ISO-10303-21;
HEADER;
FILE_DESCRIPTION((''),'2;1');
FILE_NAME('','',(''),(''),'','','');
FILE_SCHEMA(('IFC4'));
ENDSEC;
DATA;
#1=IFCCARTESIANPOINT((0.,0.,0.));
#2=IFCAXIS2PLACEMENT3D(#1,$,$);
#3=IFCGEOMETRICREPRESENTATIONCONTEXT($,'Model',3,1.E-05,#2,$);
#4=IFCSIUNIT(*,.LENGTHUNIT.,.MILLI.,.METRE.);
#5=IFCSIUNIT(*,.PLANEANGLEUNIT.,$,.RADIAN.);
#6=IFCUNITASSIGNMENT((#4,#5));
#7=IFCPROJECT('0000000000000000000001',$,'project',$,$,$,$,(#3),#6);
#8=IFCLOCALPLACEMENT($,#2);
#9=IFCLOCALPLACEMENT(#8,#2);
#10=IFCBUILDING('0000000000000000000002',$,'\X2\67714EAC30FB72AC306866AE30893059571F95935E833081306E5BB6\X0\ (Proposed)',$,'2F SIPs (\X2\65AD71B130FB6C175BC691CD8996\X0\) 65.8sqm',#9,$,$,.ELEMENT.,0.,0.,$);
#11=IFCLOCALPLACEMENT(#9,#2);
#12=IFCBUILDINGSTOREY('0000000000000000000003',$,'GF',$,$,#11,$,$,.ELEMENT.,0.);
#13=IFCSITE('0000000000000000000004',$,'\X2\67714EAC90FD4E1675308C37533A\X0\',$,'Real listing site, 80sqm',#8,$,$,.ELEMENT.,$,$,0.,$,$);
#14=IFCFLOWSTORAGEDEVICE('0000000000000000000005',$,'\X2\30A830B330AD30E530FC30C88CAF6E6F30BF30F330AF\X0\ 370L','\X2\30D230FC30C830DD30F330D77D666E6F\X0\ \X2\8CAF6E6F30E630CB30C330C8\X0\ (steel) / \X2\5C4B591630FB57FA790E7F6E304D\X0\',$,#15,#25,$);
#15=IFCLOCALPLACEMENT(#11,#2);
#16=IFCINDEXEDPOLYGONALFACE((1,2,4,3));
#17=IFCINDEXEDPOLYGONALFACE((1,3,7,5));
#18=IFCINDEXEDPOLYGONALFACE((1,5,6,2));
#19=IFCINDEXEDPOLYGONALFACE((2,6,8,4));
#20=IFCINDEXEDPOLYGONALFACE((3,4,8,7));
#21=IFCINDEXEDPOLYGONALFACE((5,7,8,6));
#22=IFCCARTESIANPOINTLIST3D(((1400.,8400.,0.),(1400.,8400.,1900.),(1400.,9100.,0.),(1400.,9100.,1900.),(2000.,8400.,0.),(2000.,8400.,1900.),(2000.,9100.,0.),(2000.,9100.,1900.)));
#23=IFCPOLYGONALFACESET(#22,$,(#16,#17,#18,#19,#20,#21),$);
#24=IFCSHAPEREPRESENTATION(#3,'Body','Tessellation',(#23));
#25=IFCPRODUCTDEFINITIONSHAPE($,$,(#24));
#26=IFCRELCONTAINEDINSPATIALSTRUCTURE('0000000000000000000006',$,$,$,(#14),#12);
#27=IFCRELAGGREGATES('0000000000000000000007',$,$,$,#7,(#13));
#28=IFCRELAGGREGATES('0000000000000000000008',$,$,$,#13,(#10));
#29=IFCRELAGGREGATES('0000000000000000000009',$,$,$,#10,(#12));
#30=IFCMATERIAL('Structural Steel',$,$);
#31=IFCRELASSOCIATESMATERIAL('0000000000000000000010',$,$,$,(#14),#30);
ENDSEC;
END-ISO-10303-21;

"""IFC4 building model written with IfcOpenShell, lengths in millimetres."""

from ifc_helpers import new_model, si_unit, frame, frame_2d, origin, place, context, project, spatial, rectangle, extrude, material, element, save


model = new_model("IFC4")

# Units and contexts
model_context = context("Model", 3, precision=1e-05, world=origin())
ifc_project = project(units=[si_unit("LENGTHUNIT", "METRE", prefix="MILLI"), si_unit("PLANEANGLEUNIT", "RADIAN")], contexts=[model_context])

# Site, building, storey
site_placement = place(None, origin())
site = spatial("IfcSite", under=ifc_project, at=site_placement, Name="東京都世田谷区", ObjectType="Real listing site, 80sqm", CompositionType="ELEMENT", RefElevation=0.0)
building_placement = place(site_placement, origin())
building = spatial("IfcBuilding", under=site, at=building_placement, Name="東京・犬と暮らす土間広めの家 (Proposed)", ObjectType="2F SIPs (断熱・気密重視) 65.8sqm", CompositionType="ELEMENT", ElevationOfRefHeight=0.0, ElevationOfTerrain=0.0)
storey_placement = place(building_placement, origin())
storey = spatial("IfcBuildingStorey", under=building, at=storey_placement, Name="GF", CompositionType="ELEMENT", Elevation=0.0)

# Flow storage device
ifc_material_1 = material(Name="Structural Steel")
flow_storage_device_placement = place(storey_placement, frame((700.0, 4200.0, 0.0)))
element("IfcFlowStorageDevice", 1, at=flow_storage_device_placement, inside=storey, material=ifc_material_1, Name="エコキュート貯湯タンク 370L", Description="ヒートポンプ給湯 貯湯ユニット (steel) / 屋外・基礎置き", context=model_context, shape_type="SweptSolid", body=[
    extrude(rectangle(XDim=600.0, YDim=700.0, at=frame_2d((300.0, 350.0))), frame((700.0, 4200.0, 0.0)), (0.0, 0.0, 1.0), 1900.0),
])

save(model, "model.ifc")
